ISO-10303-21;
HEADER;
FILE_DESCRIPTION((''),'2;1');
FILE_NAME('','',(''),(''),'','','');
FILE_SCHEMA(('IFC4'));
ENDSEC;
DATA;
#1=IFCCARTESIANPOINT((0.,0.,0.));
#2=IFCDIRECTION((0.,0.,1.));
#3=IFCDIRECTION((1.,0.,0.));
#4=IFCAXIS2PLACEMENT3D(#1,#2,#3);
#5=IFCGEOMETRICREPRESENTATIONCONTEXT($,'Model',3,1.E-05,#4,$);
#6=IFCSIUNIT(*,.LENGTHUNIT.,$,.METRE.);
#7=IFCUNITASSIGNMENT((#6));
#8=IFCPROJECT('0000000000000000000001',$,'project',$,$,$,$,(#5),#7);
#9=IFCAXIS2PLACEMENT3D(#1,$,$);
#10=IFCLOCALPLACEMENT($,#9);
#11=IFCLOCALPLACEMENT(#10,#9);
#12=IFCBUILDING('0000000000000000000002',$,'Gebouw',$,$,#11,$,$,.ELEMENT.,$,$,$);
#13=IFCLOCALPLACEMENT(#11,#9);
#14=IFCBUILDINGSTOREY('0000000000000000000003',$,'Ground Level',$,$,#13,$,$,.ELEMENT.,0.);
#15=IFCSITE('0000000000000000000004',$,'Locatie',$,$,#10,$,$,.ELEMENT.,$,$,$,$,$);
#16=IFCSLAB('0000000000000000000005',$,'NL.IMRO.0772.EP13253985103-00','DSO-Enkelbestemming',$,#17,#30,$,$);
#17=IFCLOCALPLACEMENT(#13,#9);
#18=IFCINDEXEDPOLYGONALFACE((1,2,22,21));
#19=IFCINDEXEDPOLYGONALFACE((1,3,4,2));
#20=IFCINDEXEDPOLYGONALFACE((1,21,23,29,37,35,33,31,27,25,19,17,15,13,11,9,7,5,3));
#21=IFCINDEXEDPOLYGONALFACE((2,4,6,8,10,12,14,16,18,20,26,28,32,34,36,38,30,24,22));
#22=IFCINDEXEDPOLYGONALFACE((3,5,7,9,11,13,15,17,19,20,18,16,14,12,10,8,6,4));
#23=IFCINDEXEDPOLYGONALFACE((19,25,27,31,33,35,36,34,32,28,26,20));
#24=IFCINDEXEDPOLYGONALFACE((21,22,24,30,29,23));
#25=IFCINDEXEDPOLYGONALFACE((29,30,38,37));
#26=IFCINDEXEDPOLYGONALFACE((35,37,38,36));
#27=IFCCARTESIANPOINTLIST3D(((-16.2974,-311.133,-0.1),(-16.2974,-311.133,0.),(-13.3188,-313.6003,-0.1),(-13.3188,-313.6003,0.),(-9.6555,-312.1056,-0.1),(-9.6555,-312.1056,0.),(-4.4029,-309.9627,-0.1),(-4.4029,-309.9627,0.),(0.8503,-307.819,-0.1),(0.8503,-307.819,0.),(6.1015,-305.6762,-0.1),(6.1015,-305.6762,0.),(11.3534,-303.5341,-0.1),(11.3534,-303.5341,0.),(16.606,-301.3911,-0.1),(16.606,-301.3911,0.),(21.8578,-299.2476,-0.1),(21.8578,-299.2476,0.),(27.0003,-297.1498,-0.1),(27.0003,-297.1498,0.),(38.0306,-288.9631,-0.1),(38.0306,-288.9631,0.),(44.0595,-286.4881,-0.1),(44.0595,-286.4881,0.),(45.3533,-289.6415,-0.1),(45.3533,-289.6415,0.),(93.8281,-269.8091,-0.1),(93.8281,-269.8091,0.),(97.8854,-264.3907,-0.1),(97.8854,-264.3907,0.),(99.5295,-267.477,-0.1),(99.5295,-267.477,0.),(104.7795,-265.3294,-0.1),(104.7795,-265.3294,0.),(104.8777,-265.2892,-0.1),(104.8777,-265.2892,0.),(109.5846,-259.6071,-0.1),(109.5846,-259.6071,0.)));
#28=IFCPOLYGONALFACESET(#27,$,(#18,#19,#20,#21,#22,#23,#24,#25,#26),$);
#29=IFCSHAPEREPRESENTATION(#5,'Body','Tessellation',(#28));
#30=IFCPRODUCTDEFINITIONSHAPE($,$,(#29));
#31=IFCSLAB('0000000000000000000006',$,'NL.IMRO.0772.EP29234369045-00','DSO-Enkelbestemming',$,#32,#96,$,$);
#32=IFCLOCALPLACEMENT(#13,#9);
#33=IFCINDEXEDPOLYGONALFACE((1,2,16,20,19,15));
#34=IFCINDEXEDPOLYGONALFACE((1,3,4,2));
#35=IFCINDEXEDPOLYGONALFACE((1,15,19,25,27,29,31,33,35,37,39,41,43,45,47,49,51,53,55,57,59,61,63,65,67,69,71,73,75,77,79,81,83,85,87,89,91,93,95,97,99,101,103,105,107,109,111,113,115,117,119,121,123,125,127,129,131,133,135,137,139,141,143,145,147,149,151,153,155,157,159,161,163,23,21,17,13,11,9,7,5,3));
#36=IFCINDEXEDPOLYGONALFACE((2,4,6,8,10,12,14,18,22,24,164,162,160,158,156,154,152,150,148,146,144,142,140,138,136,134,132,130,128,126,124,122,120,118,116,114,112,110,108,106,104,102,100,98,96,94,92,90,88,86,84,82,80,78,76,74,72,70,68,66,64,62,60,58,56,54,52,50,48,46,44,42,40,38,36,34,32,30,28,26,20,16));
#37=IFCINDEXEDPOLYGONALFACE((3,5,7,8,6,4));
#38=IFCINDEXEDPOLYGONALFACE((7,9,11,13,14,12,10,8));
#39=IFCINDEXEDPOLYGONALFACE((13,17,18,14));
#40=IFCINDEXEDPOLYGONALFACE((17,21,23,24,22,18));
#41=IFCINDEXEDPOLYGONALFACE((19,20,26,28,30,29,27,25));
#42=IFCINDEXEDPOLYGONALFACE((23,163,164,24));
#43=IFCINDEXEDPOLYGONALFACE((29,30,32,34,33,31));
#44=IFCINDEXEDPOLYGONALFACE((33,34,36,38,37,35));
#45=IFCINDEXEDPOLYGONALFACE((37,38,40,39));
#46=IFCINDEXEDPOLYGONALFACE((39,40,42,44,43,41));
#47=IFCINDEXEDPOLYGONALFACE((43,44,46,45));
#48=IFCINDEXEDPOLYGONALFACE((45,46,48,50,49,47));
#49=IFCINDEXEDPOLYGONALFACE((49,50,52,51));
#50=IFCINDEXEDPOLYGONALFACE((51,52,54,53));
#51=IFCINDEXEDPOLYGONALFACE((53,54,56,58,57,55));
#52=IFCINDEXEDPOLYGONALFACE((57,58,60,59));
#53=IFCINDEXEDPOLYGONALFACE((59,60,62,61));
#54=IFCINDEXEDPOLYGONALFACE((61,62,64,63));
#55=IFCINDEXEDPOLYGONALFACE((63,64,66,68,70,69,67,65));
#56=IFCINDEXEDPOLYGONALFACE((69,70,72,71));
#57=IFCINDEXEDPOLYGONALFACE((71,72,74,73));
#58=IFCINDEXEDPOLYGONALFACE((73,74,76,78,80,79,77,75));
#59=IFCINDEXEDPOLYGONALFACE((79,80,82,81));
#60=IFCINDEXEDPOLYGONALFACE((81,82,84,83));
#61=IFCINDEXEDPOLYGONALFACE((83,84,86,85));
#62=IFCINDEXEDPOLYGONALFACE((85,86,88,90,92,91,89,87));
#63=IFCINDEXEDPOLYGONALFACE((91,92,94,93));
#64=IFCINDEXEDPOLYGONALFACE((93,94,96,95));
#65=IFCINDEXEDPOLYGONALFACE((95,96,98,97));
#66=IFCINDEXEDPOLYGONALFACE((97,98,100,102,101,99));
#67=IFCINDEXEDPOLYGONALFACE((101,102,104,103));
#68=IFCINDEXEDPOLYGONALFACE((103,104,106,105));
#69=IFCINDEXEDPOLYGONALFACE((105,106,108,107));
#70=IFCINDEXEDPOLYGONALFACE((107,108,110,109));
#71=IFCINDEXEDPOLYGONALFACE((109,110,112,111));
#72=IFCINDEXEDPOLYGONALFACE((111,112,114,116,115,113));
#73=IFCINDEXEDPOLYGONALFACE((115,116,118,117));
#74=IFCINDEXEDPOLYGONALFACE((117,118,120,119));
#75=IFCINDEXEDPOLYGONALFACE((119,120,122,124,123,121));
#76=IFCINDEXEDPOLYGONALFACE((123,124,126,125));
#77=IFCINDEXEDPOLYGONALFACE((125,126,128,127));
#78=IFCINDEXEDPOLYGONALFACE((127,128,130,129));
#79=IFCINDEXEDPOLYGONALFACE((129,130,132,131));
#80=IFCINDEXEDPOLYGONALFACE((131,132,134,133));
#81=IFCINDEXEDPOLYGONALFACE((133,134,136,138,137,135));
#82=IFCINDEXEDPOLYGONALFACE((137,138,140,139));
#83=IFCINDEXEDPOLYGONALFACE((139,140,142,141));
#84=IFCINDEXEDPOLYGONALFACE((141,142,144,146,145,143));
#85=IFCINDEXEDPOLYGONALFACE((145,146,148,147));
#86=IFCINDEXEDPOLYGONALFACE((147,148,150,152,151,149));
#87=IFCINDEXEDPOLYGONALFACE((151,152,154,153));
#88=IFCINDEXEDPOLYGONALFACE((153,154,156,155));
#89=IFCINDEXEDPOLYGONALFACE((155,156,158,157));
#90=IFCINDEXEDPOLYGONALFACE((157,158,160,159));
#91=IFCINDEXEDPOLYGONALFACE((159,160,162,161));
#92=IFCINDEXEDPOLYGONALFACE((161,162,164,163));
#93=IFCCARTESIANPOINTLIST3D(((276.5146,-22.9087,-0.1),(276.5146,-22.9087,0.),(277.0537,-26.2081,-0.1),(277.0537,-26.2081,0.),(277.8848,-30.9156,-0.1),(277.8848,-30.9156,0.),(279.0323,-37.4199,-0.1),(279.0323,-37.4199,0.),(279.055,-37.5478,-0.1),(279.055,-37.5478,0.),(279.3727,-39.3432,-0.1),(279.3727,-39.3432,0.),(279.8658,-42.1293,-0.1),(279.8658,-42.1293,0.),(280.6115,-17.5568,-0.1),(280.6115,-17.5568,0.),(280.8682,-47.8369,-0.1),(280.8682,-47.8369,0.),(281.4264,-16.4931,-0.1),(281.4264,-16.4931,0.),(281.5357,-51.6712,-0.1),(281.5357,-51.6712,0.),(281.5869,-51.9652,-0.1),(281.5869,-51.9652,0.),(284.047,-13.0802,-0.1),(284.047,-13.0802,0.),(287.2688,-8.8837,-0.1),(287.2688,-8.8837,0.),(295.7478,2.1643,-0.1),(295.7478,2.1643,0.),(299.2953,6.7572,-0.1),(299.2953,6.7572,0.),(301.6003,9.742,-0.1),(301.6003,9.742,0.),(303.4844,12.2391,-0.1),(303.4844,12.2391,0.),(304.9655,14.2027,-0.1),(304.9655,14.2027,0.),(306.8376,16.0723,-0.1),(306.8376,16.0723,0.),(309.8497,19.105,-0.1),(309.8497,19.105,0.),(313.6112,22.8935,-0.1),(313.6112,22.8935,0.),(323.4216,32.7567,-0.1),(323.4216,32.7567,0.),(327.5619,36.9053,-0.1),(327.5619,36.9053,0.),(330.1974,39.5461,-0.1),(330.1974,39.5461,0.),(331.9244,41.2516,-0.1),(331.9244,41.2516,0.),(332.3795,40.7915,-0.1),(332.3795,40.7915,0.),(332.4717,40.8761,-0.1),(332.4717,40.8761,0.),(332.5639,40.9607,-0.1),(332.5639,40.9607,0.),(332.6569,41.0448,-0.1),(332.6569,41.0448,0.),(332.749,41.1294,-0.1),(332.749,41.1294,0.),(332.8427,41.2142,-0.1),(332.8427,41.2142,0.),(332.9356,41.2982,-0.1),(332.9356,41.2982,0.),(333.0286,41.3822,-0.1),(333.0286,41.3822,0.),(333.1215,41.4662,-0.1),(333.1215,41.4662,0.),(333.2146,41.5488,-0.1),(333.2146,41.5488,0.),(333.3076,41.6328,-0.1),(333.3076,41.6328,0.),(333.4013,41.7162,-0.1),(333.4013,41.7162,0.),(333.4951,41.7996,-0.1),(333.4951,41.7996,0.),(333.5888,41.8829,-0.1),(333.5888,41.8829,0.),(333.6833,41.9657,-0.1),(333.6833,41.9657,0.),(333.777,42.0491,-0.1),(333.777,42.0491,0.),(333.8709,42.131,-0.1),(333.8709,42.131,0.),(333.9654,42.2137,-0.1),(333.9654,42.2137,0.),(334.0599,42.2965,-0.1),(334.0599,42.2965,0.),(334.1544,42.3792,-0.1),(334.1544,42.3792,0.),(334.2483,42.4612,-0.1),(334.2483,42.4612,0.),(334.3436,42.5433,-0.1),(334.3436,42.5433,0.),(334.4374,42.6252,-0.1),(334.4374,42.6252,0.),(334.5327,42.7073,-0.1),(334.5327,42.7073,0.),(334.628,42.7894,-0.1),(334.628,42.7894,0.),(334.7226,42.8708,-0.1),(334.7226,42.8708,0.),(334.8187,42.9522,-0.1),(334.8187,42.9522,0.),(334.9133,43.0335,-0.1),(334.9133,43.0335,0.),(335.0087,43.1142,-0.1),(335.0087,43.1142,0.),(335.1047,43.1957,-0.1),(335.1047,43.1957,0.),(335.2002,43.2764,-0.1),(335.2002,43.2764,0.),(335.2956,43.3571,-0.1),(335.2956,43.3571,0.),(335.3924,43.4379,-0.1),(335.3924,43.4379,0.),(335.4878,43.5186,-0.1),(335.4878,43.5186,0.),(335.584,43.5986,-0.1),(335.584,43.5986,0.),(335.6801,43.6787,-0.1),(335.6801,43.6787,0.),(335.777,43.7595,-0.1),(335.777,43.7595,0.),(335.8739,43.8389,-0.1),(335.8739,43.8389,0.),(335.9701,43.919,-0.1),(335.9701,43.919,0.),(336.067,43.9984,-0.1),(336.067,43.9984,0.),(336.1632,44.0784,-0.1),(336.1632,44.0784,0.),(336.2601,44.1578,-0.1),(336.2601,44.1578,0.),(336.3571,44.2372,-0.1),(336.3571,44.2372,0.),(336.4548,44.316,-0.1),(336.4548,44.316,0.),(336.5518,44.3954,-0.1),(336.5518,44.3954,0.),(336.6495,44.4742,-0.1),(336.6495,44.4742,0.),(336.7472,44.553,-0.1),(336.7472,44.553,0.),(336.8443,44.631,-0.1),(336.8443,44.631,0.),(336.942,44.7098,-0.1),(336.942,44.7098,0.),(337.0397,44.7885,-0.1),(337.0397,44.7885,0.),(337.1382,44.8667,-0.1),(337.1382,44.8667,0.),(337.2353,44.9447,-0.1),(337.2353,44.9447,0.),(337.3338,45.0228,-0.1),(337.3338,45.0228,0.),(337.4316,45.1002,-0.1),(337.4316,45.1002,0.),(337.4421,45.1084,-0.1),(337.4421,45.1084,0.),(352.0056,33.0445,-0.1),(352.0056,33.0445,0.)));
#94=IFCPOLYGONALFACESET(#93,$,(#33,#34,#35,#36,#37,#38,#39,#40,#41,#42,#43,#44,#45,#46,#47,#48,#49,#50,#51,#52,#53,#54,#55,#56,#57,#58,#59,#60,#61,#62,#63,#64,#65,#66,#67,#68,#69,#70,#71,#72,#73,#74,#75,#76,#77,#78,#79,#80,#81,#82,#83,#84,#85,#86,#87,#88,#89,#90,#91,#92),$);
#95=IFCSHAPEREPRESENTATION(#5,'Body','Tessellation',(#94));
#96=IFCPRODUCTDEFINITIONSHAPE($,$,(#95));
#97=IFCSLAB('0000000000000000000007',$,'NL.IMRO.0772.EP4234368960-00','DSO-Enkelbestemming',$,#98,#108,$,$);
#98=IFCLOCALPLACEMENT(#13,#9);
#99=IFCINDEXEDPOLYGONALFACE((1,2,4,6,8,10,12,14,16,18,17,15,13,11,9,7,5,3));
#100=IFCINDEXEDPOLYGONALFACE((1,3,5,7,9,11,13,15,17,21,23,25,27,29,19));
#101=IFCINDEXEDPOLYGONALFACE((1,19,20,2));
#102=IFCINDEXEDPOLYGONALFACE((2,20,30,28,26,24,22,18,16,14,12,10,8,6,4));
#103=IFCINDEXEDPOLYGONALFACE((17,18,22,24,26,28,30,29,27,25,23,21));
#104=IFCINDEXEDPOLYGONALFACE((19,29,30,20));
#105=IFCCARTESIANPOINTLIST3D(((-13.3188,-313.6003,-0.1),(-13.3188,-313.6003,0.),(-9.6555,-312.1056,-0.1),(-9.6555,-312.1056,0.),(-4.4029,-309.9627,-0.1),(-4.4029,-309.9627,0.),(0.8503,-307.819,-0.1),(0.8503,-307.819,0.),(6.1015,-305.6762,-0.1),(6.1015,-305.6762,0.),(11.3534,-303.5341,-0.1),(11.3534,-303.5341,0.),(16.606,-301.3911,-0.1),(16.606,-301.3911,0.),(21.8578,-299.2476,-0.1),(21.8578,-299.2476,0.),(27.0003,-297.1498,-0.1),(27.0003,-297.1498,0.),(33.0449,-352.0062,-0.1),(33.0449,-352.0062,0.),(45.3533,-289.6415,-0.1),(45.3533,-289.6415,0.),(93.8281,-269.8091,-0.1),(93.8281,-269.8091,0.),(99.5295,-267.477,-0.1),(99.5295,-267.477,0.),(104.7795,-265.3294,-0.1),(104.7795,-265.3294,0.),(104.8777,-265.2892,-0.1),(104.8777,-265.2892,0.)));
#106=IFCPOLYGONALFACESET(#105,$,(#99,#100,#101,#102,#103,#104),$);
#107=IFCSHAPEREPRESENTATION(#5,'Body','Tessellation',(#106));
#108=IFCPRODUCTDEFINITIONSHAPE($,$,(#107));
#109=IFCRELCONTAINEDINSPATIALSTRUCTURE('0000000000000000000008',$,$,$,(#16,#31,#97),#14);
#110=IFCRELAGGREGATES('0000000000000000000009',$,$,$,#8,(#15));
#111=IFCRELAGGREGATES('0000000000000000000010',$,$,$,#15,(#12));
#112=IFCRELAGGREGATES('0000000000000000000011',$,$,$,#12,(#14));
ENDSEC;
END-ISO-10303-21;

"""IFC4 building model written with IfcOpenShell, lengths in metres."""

from ifc_helpers import new_model, si_unit, frame, origin, origin_with_axes, place, context, project, spatial, polyline, outline, extrude, element, save


model = new_model("IFC4")

# Units and contexts
model_context = context("Model", 3, precision=1e-05, world=origin_with_axes())
ifc_project = project(units=[si_unit("LENGTHUNIT", "METRE")], contexts=[model_context])

# Site, building, storey
site_placement = place(None, origin())
site = spatial("IfcSite", under=ifc_project, at=site_placement, Name="Locatie", CompositionType="ELEMENT")
building_placement = place(site_placement, origin())
building = spatial("IfcBuilding", under=site, at=building_placement, Name="Gebouw", CompositionType="ELEMENT")
storey_placement = place(building_placement, origin())
storey = spatial("IfcBuildingStorey", under=building, at=storey_placement, Name="Ground Level", CompositionType="ELEMENT", Elevation=0.0)

# Slabs
slab_1_placement = place(storey_placement, origin())
element("IfcSlab", 1, at=slab_1_placement, inside=storey, Name="NL.IMRO.0772.EP13253985103-00", Description="DSO-Enkelbestemming", context=model_context, shape_type="SweptSolid", body=[
    extrude(outline(polyline([(38.0306, -288.9631), (44.0595, -286.4881), (97.8854, -264.3907), (109.5846, -259.6071), (104.8777, -265.2892), (104.7795, -265.3294), (99.5295, -267.477), (93.8281, -269.8091), (45.3533, -289.6415), (27.0003, -297.1498), (21.8578, -299.2476), (16.606, -301.3911), (11.3534, -303.5341), (6.1015, -305.6762), (0.8503, -307.819), (-4.4029, -309.9627), (-9.6555, -312.1056), (-13.3188, -313.6003), (-16.2974, -311.133), (38.0306, -288.9631)])), frame((0.0, 0.0, -0.1), z_axis=(0.0, 0.0, 1.0), x_axis=(1.0, 0.0, 0.0)), (0.0, 0.0, 1.0), 0.1),
])
slab_2_placement = place(storey_placement, origin())
element("IfcSlab", 2, at=slab_2_placement, inside=storey, Name="NL.IMRO.0772.EP29234369045-00", Description="DSO-Enkelbestemming", context=model_context, shape_type="SweptSolid", body=[
    extrude(outline(polyline([(281.5357, -51.6712), (280.8682, -47.8369), (279.8658, -42.1293), (279.3727, -39.3432), (279.055, -37.5478), (279.0323, -37.4199), (277.8848, -30.9156), (277.0537, -26.2081), (276.5146, -22.9087), (280.6115, -17.5568), (281.4264, -16.4931), (284.047, -13.0802), (287.2688, -8.8837), (295.7478, 2.1643), (299.2953, 6.7572), (301.6003, 9.742), (303.4844, 12.2391), (304.9655, 14.2027), (306.8376, 16.0723), (309.8497, 19.105), (313.6112, 22.8935), (323.4216, 32.7567), (327.5619, 36.9053), (330.1974, 39.5461), (331.9244, 41.2516), (332.3795, 40.7915), (332.4717, 40.8761), (332.5639, 40.9607), (332.6569, 41.0448), (332.749, 41.1294), (332.8427, 41.2142), (332.9356, 41.2982), (333.0286, 41.3822), (333.1215, 41.4662), (333.2146, 41.5488), (333.3076, 41.6328), (333.4013, 41.7162), (333.4951, 41.7996), (333.5888, 41.8829), (333.6833, 41.9657), (333.777, 42.0491), (333.8709, 42.131), (333.9654, 42.2137), (334.0599, 42.2965), (334.1544, 42.3792), (334.2483, 42.4612), (334.3436, 42.5433), (334.4374, 42.6252), (334.5327, 42.7073), (334.628, 42.7894), (334.7226, 42.8708), (334.8187, 42.9522), (334.9133, 43.0335), (335.0087, 43.1142), (335.1047, 43.1957), (335.2002, 43.2764), (335.2956, 43.3571), (335.3924, 43.4379), (335.4878, 43.5186), (335.584, 43.5986), (335.6801, 43.6787), (335.777, 43.7595), (335.8739, 43.8389), (335.9701, 43.919), (336.067, 43.9984), (336.1632, 44.0784), (336.2601, 44.1578), (336.3571, 44.2372), (336.4548, 44.316), (336.5518, 44.3954), (336.6495, 44.4742), (336.7472, 44.553), (336.8443, 44.631), (336.942, 44.7098), (337.0397, 44.7885), (337.1382, 44.8667), (337.2353, 44.9447), (337.3338, 45.0228), (337.4316, 45.1002), (337.4421, 45.1084), (352.0056, 33.0445), (281.5869, -51.9652), (281.5357, -51.6712)])), frame((0.0, 0.0, -0.1), z_axis=(0.0, 0.0, 1.0), x_axis=(1.0, 0.0, 0.0)), (0.0, 0.0, 1.0), 0.1),
])
slab_3_placement = place(storey_placement, origin())
element("IfcSlab", 3, at=slab_3_placement, inside=storey, Name="NL.IMRO.0772.EP4234368960-00", Description="DSO-Enkelbestemming", context=model_context, shape_type="SweptSolid", body=[
    extrude(outline(polyline([(-9.6555, -312.1056), (-4.4029, -309.9627), (0.8503, -307.819), (6.1015, -305.6762), (11.3534, -303.5341), (16.606, -301.3911), (21.8578, -299.2476), (27.0003, -297.1498), (45.3533, -289.6415), (93.8281, -269.8091), (99.5295, -267.477), (104.7795, -265.3294), (104.8777, -265.2892), (33.0449, -352.0062), (-13.3188, -313.6003), (-9.6555, -312.1056)])), frame((0.0, 0.0, -0.1), z_axis=(0.0, 0.0, 1.0), x_axis=(1.0, 0.0, 0.0)), (0.0, 0.0, 1.0), 0.1),
])

save(model, "model.ifc")
